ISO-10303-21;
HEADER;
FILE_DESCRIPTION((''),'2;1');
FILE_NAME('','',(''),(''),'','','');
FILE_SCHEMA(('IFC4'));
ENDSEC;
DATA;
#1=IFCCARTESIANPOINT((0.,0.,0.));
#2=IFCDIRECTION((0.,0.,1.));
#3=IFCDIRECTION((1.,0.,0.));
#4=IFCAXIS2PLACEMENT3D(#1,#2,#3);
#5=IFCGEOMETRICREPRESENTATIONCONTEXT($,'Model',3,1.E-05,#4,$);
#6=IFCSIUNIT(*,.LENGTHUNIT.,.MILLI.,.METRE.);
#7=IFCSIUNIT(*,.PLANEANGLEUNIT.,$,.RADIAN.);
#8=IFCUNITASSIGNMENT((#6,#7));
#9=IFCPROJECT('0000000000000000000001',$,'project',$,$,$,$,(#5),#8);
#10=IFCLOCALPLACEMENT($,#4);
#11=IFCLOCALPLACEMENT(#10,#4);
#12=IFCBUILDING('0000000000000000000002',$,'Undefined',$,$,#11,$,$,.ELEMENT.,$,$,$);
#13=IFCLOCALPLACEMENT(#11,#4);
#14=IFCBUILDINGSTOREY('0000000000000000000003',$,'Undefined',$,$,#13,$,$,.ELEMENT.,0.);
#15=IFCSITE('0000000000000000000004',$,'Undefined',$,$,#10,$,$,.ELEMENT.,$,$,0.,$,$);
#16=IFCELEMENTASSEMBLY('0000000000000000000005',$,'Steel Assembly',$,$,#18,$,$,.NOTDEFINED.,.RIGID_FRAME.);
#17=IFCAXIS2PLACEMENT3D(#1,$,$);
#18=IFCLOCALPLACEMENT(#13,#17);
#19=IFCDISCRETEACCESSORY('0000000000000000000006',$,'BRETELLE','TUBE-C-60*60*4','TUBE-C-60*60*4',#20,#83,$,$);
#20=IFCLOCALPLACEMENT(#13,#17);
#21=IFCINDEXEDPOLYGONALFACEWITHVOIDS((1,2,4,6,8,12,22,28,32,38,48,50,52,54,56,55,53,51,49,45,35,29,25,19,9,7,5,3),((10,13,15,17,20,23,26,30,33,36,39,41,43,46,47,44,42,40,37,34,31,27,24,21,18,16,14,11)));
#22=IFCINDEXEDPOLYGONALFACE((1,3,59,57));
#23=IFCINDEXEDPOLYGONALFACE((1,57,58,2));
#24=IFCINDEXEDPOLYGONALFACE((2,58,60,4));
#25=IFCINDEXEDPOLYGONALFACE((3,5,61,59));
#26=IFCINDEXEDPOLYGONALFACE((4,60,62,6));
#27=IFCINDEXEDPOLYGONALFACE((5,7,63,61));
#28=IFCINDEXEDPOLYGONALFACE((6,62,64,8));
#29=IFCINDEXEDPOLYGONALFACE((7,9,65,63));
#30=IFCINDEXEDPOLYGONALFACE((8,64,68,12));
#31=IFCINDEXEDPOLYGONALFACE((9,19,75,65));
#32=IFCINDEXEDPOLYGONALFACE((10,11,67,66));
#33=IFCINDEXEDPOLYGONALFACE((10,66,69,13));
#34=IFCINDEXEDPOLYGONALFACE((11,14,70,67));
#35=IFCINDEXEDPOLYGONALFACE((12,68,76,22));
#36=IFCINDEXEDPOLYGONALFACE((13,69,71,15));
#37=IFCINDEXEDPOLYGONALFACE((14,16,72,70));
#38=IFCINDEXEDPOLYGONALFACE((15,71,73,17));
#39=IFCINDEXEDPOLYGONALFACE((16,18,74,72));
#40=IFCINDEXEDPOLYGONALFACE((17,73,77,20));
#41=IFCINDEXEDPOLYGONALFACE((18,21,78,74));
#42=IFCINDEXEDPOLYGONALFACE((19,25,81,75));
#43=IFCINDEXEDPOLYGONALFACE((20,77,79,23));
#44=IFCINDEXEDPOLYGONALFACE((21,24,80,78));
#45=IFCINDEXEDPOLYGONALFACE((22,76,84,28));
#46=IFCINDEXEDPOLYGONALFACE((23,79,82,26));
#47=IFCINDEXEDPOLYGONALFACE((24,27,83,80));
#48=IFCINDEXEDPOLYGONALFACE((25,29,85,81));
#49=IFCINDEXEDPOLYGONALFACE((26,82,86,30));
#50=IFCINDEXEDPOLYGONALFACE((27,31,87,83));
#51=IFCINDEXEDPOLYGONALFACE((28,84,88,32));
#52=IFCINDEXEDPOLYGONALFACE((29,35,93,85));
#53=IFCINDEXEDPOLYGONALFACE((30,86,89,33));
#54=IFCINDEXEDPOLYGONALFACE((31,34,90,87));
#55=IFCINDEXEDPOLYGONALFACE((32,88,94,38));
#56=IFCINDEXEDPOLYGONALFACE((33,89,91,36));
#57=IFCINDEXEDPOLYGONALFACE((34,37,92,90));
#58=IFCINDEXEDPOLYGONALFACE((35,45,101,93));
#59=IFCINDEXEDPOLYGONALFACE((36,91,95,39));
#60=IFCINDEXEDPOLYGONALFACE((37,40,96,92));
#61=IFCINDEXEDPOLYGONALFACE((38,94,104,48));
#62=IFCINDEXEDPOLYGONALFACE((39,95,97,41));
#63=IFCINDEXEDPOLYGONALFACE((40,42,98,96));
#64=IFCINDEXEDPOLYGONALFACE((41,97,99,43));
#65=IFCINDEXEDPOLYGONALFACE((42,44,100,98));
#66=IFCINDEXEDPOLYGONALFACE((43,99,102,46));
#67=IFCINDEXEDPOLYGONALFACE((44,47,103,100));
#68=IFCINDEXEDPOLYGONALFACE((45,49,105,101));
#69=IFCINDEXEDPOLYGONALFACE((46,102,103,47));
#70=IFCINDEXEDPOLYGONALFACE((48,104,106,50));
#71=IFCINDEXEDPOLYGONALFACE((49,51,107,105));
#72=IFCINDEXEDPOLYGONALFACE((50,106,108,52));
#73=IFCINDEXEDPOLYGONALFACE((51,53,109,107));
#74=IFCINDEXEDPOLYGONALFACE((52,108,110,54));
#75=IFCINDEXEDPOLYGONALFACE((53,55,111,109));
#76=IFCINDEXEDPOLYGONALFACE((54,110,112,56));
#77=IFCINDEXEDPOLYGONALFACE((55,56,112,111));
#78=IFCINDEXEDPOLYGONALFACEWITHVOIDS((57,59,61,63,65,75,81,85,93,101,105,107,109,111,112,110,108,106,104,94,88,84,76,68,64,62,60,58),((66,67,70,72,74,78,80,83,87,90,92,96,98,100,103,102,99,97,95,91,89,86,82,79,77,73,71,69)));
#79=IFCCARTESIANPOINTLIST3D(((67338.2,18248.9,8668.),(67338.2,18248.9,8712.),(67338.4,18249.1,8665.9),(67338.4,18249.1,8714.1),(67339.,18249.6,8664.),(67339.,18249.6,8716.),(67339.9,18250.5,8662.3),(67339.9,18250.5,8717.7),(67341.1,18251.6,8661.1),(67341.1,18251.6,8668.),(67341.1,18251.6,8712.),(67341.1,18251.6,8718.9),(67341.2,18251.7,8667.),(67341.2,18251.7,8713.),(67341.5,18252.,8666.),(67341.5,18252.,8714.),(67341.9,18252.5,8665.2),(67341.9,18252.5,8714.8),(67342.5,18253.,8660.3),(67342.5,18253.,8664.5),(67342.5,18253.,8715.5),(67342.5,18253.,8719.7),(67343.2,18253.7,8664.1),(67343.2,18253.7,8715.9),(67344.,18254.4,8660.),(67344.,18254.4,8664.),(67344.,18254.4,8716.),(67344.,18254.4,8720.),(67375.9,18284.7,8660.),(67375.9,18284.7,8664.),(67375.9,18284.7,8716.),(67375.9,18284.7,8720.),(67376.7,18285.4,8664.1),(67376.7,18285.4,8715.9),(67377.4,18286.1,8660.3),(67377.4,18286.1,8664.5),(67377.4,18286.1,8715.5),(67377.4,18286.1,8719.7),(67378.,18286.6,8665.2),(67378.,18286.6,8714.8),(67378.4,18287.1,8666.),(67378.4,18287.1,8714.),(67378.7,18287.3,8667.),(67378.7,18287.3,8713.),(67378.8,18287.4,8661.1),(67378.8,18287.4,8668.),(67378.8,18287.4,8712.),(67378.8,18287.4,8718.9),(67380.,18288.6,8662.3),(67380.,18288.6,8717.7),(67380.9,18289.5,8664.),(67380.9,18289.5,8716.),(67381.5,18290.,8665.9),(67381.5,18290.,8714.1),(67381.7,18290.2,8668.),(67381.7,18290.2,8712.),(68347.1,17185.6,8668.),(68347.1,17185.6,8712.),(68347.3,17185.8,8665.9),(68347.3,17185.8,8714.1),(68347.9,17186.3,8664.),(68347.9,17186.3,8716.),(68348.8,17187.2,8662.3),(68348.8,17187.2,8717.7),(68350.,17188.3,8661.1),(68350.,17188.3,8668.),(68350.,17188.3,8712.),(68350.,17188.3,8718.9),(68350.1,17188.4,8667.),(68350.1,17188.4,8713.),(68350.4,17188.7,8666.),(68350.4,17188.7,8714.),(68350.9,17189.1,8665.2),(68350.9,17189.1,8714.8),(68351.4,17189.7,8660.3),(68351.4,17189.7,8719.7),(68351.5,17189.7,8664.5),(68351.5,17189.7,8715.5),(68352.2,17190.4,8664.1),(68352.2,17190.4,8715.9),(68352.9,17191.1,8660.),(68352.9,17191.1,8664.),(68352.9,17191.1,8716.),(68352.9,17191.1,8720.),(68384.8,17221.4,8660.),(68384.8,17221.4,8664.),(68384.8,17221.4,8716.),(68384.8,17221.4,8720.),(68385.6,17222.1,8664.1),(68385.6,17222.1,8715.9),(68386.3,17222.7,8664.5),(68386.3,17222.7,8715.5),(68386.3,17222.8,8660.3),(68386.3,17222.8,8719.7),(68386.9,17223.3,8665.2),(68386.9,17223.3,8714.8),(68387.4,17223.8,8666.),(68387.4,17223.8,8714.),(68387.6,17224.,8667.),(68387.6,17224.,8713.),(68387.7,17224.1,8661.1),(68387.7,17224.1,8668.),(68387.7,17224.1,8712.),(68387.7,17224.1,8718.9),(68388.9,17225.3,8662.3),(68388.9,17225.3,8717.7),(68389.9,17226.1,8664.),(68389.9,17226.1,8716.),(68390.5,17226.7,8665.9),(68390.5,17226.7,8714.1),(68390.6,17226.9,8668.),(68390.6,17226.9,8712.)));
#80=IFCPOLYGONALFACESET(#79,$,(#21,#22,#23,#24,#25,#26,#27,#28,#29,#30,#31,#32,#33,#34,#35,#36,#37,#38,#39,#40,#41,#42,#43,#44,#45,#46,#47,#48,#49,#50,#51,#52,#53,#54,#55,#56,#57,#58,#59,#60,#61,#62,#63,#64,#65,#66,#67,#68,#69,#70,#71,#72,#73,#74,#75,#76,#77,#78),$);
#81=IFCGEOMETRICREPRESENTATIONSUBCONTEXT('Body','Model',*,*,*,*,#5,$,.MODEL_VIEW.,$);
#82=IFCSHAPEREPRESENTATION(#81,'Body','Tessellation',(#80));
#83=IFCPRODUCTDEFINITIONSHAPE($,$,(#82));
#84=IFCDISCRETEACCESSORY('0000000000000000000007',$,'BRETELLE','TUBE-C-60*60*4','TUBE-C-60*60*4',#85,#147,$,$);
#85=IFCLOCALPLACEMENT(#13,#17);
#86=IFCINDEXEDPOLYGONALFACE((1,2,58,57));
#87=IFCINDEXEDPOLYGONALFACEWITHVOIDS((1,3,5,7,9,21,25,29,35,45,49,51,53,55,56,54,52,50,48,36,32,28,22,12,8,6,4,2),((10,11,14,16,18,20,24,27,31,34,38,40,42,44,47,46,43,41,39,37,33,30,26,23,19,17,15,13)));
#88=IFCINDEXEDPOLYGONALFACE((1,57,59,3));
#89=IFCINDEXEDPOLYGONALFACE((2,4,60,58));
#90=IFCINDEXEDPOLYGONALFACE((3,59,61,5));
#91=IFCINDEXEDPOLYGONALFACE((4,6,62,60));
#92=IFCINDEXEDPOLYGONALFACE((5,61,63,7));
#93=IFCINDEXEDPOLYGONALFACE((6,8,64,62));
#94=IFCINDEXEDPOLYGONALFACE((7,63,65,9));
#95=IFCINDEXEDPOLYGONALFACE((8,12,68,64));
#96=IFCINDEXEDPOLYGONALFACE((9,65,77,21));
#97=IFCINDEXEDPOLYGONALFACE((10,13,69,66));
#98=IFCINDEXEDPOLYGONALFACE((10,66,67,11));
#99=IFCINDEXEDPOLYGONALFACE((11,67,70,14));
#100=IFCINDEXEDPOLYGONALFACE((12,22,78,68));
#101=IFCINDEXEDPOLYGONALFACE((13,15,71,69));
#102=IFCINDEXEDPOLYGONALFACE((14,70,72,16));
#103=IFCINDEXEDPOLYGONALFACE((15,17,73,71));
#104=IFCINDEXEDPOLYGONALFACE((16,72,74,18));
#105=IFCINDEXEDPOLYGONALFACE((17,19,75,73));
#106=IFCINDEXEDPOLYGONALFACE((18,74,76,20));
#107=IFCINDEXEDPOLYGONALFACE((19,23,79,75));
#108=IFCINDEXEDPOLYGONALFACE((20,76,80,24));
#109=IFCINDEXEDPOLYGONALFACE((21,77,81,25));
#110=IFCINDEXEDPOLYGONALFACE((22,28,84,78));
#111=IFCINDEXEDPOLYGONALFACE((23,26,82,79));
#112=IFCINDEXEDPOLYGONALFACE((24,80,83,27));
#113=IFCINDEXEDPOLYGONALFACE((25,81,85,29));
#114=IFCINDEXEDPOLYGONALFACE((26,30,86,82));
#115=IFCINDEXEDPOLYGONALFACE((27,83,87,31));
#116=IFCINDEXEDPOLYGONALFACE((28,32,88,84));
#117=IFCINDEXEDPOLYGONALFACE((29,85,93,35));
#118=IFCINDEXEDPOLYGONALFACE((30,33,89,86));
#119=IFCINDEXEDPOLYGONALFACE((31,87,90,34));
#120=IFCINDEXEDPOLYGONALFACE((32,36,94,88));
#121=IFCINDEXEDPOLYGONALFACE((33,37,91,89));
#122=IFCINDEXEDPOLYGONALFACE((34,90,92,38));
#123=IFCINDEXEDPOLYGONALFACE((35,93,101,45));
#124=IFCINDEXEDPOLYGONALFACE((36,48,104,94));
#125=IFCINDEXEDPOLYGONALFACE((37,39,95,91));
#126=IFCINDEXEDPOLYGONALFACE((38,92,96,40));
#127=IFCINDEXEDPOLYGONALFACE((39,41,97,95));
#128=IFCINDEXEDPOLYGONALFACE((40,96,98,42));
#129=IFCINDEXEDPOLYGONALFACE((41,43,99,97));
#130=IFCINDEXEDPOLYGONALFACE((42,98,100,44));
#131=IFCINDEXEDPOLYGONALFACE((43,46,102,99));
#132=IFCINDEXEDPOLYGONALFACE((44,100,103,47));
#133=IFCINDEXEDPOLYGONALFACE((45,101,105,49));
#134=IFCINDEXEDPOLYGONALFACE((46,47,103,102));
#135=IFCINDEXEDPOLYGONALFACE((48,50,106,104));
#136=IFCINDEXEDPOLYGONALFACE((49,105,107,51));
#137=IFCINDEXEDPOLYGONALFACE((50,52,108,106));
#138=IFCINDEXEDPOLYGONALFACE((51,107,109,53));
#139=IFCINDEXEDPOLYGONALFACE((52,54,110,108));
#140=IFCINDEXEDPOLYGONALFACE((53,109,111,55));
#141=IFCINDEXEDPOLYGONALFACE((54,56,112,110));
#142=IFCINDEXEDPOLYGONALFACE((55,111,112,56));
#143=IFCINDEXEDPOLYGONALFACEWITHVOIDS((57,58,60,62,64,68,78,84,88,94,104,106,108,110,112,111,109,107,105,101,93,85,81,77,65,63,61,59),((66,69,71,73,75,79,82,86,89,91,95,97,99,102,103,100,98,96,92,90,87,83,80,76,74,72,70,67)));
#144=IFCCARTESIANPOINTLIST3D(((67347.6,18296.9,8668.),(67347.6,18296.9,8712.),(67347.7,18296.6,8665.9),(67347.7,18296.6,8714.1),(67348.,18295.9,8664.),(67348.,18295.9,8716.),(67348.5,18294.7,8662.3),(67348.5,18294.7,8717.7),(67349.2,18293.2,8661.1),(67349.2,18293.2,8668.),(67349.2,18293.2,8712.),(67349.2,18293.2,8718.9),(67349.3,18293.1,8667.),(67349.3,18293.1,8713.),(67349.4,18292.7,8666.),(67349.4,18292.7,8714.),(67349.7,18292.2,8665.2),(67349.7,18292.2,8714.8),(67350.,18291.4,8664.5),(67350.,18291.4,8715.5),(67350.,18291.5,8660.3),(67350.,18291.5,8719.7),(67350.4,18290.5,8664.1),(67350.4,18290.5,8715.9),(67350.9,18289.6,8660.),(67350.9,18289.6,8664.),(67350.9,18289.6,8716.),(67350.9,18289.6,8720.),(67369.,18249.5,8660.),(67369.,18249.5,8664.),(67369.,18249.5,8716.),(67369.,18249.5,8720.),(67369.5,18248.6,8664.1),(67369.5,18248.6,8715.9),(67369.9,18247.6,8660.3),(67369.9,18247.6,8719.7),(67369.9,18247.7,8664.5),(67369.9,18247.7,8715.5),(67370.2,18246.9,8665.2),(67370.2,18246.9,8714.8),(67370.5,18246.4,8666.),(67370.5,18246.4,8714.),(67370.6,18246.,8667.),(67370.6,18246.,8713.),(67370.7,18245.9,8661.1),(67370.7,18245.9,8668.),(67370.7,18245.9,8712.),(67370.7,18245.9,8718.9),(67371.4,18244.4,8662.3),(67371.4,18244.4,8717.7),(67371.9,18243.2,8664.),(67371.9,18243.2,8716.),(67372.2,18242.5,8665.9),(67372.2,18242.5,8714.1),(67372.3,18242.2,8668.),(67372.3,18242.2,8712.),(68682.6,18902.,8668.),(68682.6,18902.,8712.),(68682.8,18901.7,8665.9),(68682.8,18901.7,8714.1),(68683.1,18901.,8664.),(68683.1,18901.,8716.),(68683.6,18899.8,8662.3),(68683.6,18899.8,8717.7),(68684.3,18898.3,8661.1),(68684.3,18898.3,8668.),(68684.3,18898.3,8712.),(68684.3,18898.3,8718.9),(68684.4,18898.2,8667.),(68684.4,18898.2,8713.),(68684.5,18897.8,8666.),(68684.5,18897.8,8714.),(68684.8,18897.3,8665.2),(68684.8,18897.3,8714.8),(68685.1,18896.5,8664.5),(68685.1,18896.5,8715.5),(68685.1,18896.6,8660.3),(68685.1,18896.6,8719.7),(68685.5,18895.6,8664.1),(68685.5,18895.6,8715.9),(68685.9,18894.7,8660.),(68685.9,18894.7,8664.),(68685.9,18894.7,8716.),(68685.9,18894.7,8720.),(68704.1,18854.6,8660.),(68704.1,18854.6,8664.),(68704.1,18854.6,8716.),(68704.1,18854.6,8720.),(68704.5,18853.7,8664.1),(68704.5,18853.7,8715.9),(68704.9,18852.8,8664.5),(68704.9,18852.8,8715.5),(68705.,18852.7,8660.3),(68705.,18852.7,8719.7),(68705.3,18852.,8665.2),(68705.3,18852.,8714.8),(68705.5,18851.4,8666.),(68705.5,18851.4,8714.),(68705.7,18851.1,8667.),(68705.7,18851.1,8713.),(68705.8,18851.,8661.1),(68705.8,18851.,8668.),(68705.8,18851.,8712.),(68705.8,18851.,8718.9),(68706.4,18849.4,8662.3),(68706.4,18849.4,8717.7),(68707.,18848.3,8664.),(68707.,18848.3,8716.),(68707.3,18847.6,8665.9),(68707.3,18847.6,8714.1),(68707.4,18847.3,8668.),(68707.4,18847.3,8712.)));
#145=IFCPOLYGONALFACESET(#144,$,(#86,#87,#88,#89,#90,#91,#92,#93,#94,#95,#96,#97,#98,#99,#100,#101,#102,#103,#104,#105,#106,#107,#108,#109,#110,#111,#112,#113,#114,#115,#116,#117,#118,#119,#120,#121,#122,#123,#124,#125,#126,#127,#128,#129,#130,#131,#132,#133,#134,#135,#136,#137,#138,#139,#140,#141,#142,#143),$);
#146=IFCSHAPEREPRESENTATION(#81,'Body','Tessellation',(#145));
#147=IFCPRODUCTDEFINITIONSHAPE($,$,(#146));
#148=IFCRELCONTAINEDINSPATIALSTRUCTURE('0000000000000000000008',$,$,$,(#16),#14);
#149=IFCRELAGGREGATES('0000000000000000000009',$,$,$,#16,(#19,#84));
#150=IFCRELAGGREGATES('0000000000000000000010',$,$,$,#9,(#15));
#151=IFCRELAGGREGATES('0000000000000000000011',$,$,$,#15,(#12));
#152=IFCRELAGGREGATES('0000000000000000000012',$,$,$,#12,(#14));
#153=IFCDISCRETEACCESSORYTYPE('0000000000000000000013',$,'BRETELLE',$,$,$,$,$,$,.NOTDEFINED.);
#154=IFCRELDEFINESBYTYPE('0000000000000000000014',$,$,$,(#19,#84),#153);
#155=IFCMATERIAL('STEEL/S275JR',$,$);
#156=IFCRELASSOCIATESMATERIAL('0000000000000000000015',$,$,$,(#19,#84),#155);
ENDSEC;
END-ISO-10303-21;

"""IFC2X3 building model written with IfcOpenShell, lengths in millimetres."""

from ifc_helpers import new_model, si_unit, frame, origin_with_axes, origin_2d_with_axis, place, context, subcontext, project, spatial, hollow_rectangle, extrude, material, type_object, element, aggregate, save


model = new_model("IFC2X3")

# Units and contexts
model_context = context("Model", 3, precision=1e-05, world=origin_with_axes())
body_context = subcontext(model_context, "Body", "Model", "MODEL_VIEW")
ifc_project = project(units=[si_unit("LENGTHUNIT", "METRE", prefix="MILLI"), si_unit("PLANEANGLEUNIT", "RADIAN")], contexts=[model_context])

# Site, building, storey
site_placement = place(None, origin_with_axes())
site = spatial("IfcSite", under=ifc_project, at=site_placement, Name="Undefined", CompositionType="ELEMENT", RefElevation=0.0)
building_placement = place(site_placement, origin_with_axes())
building = spatial("IfcBuilding", under=site, at=building_placement, Name="Undefined", CompositionType="ELEMENT")
storey_placement = place(building_placement, origin_with_axes())
storey = spatial("IfcBuildingStorey", under=building, at=storey_placement, Name="Undefined", CompositionType="ELEMENT", Elevation=0.0)

# Shared definitions
ifc_material = material(Name="STEEL/S275JR")

# Element assembly, discrete accessories
assembly_1_placement = place(storey_placement, origin_with_axes())
assembly_1 = element("IfcElementAssembly", 1, at=assembly_1_placement, inside=storey, Name="Steel Assembly", AssemblyPlace="NOTDEFINED", PredefinedType="RIGID_FRAME")
discrete_accessory_type_1 = type_object("IfcDiscreteAccessoryType", Name="BRETELLE")
discrete_accessory_1_placement = place(assembly_1_placement, frame((67359.9, 18269.6, 8690.0), z_axis=(0.725416, 0.688311, 0.0), x_axis=(0.688311, -0.725416, 0.0)))
discrete_accessory_1 = element("IfcDiscreteAccessory", 2, at=discrete_accessory_1_placement, type_object=discrete_accessory_type_1, material=ifc_material, Name="BRETELLE", Description="TUBE-C-60*60*4", ObjectType="TUBE-C-60*60*4", context=body_context, shape_type="SweptSolid", body=[
    extrude(hollow_rectangle(XDim=60.0, YDim=60.0, WallThickness=4.0, InnerFilletRadius=4.0, OuterFilletRadius=8.0, at=origin_2d_with_axis()), frame((1465.8, 0.0, 0.0), z_axis=(-1.0, 0.0, 0.0), x_axis=(0.0, -1.0, 0.0)), (0.0, 0.0, 1.0), 1465.8),
])
discrete_accessory_2_placement = place(assembly_1_placement, frame((68695.0, 18874.6, 8690.0), z_axis=(-0.412799, 0.910822, 0.0), x_axis=(-0.910822, -0.412799, 0.0)))
discrete_accessory_2 = element("IfcDiscreteAccessory", 3, at=discrete_accessory_2_placement, type_object=discrete_accessory_type_1, material=ifc_material, Name="BRETELLE", Description="TUBE-C-60*60*4", ObjectType="TUBE-C-60*60*4", context=body_context, shape_type="SweptSolid", body=[
    extrude(hollow_rectangle(XDim=60.0, YDim=60.0, WallThickness=4.0, InnerFilletRadius=4.0, OuterFilletRadius=8.0, at=origin_2d_with_axis()), frame((1465.8, 0.0, 0.0), z_axis=(-1.0, 0.0, 0.0), x_axis=(0.0, -1.0, 0.0)), (0.0, 0.0, 1.0), 1465.8),
])
aggregate(assembly_1, [discrete_accessory_1, discrete_accessory_2])

save(model, "model.ifc")
